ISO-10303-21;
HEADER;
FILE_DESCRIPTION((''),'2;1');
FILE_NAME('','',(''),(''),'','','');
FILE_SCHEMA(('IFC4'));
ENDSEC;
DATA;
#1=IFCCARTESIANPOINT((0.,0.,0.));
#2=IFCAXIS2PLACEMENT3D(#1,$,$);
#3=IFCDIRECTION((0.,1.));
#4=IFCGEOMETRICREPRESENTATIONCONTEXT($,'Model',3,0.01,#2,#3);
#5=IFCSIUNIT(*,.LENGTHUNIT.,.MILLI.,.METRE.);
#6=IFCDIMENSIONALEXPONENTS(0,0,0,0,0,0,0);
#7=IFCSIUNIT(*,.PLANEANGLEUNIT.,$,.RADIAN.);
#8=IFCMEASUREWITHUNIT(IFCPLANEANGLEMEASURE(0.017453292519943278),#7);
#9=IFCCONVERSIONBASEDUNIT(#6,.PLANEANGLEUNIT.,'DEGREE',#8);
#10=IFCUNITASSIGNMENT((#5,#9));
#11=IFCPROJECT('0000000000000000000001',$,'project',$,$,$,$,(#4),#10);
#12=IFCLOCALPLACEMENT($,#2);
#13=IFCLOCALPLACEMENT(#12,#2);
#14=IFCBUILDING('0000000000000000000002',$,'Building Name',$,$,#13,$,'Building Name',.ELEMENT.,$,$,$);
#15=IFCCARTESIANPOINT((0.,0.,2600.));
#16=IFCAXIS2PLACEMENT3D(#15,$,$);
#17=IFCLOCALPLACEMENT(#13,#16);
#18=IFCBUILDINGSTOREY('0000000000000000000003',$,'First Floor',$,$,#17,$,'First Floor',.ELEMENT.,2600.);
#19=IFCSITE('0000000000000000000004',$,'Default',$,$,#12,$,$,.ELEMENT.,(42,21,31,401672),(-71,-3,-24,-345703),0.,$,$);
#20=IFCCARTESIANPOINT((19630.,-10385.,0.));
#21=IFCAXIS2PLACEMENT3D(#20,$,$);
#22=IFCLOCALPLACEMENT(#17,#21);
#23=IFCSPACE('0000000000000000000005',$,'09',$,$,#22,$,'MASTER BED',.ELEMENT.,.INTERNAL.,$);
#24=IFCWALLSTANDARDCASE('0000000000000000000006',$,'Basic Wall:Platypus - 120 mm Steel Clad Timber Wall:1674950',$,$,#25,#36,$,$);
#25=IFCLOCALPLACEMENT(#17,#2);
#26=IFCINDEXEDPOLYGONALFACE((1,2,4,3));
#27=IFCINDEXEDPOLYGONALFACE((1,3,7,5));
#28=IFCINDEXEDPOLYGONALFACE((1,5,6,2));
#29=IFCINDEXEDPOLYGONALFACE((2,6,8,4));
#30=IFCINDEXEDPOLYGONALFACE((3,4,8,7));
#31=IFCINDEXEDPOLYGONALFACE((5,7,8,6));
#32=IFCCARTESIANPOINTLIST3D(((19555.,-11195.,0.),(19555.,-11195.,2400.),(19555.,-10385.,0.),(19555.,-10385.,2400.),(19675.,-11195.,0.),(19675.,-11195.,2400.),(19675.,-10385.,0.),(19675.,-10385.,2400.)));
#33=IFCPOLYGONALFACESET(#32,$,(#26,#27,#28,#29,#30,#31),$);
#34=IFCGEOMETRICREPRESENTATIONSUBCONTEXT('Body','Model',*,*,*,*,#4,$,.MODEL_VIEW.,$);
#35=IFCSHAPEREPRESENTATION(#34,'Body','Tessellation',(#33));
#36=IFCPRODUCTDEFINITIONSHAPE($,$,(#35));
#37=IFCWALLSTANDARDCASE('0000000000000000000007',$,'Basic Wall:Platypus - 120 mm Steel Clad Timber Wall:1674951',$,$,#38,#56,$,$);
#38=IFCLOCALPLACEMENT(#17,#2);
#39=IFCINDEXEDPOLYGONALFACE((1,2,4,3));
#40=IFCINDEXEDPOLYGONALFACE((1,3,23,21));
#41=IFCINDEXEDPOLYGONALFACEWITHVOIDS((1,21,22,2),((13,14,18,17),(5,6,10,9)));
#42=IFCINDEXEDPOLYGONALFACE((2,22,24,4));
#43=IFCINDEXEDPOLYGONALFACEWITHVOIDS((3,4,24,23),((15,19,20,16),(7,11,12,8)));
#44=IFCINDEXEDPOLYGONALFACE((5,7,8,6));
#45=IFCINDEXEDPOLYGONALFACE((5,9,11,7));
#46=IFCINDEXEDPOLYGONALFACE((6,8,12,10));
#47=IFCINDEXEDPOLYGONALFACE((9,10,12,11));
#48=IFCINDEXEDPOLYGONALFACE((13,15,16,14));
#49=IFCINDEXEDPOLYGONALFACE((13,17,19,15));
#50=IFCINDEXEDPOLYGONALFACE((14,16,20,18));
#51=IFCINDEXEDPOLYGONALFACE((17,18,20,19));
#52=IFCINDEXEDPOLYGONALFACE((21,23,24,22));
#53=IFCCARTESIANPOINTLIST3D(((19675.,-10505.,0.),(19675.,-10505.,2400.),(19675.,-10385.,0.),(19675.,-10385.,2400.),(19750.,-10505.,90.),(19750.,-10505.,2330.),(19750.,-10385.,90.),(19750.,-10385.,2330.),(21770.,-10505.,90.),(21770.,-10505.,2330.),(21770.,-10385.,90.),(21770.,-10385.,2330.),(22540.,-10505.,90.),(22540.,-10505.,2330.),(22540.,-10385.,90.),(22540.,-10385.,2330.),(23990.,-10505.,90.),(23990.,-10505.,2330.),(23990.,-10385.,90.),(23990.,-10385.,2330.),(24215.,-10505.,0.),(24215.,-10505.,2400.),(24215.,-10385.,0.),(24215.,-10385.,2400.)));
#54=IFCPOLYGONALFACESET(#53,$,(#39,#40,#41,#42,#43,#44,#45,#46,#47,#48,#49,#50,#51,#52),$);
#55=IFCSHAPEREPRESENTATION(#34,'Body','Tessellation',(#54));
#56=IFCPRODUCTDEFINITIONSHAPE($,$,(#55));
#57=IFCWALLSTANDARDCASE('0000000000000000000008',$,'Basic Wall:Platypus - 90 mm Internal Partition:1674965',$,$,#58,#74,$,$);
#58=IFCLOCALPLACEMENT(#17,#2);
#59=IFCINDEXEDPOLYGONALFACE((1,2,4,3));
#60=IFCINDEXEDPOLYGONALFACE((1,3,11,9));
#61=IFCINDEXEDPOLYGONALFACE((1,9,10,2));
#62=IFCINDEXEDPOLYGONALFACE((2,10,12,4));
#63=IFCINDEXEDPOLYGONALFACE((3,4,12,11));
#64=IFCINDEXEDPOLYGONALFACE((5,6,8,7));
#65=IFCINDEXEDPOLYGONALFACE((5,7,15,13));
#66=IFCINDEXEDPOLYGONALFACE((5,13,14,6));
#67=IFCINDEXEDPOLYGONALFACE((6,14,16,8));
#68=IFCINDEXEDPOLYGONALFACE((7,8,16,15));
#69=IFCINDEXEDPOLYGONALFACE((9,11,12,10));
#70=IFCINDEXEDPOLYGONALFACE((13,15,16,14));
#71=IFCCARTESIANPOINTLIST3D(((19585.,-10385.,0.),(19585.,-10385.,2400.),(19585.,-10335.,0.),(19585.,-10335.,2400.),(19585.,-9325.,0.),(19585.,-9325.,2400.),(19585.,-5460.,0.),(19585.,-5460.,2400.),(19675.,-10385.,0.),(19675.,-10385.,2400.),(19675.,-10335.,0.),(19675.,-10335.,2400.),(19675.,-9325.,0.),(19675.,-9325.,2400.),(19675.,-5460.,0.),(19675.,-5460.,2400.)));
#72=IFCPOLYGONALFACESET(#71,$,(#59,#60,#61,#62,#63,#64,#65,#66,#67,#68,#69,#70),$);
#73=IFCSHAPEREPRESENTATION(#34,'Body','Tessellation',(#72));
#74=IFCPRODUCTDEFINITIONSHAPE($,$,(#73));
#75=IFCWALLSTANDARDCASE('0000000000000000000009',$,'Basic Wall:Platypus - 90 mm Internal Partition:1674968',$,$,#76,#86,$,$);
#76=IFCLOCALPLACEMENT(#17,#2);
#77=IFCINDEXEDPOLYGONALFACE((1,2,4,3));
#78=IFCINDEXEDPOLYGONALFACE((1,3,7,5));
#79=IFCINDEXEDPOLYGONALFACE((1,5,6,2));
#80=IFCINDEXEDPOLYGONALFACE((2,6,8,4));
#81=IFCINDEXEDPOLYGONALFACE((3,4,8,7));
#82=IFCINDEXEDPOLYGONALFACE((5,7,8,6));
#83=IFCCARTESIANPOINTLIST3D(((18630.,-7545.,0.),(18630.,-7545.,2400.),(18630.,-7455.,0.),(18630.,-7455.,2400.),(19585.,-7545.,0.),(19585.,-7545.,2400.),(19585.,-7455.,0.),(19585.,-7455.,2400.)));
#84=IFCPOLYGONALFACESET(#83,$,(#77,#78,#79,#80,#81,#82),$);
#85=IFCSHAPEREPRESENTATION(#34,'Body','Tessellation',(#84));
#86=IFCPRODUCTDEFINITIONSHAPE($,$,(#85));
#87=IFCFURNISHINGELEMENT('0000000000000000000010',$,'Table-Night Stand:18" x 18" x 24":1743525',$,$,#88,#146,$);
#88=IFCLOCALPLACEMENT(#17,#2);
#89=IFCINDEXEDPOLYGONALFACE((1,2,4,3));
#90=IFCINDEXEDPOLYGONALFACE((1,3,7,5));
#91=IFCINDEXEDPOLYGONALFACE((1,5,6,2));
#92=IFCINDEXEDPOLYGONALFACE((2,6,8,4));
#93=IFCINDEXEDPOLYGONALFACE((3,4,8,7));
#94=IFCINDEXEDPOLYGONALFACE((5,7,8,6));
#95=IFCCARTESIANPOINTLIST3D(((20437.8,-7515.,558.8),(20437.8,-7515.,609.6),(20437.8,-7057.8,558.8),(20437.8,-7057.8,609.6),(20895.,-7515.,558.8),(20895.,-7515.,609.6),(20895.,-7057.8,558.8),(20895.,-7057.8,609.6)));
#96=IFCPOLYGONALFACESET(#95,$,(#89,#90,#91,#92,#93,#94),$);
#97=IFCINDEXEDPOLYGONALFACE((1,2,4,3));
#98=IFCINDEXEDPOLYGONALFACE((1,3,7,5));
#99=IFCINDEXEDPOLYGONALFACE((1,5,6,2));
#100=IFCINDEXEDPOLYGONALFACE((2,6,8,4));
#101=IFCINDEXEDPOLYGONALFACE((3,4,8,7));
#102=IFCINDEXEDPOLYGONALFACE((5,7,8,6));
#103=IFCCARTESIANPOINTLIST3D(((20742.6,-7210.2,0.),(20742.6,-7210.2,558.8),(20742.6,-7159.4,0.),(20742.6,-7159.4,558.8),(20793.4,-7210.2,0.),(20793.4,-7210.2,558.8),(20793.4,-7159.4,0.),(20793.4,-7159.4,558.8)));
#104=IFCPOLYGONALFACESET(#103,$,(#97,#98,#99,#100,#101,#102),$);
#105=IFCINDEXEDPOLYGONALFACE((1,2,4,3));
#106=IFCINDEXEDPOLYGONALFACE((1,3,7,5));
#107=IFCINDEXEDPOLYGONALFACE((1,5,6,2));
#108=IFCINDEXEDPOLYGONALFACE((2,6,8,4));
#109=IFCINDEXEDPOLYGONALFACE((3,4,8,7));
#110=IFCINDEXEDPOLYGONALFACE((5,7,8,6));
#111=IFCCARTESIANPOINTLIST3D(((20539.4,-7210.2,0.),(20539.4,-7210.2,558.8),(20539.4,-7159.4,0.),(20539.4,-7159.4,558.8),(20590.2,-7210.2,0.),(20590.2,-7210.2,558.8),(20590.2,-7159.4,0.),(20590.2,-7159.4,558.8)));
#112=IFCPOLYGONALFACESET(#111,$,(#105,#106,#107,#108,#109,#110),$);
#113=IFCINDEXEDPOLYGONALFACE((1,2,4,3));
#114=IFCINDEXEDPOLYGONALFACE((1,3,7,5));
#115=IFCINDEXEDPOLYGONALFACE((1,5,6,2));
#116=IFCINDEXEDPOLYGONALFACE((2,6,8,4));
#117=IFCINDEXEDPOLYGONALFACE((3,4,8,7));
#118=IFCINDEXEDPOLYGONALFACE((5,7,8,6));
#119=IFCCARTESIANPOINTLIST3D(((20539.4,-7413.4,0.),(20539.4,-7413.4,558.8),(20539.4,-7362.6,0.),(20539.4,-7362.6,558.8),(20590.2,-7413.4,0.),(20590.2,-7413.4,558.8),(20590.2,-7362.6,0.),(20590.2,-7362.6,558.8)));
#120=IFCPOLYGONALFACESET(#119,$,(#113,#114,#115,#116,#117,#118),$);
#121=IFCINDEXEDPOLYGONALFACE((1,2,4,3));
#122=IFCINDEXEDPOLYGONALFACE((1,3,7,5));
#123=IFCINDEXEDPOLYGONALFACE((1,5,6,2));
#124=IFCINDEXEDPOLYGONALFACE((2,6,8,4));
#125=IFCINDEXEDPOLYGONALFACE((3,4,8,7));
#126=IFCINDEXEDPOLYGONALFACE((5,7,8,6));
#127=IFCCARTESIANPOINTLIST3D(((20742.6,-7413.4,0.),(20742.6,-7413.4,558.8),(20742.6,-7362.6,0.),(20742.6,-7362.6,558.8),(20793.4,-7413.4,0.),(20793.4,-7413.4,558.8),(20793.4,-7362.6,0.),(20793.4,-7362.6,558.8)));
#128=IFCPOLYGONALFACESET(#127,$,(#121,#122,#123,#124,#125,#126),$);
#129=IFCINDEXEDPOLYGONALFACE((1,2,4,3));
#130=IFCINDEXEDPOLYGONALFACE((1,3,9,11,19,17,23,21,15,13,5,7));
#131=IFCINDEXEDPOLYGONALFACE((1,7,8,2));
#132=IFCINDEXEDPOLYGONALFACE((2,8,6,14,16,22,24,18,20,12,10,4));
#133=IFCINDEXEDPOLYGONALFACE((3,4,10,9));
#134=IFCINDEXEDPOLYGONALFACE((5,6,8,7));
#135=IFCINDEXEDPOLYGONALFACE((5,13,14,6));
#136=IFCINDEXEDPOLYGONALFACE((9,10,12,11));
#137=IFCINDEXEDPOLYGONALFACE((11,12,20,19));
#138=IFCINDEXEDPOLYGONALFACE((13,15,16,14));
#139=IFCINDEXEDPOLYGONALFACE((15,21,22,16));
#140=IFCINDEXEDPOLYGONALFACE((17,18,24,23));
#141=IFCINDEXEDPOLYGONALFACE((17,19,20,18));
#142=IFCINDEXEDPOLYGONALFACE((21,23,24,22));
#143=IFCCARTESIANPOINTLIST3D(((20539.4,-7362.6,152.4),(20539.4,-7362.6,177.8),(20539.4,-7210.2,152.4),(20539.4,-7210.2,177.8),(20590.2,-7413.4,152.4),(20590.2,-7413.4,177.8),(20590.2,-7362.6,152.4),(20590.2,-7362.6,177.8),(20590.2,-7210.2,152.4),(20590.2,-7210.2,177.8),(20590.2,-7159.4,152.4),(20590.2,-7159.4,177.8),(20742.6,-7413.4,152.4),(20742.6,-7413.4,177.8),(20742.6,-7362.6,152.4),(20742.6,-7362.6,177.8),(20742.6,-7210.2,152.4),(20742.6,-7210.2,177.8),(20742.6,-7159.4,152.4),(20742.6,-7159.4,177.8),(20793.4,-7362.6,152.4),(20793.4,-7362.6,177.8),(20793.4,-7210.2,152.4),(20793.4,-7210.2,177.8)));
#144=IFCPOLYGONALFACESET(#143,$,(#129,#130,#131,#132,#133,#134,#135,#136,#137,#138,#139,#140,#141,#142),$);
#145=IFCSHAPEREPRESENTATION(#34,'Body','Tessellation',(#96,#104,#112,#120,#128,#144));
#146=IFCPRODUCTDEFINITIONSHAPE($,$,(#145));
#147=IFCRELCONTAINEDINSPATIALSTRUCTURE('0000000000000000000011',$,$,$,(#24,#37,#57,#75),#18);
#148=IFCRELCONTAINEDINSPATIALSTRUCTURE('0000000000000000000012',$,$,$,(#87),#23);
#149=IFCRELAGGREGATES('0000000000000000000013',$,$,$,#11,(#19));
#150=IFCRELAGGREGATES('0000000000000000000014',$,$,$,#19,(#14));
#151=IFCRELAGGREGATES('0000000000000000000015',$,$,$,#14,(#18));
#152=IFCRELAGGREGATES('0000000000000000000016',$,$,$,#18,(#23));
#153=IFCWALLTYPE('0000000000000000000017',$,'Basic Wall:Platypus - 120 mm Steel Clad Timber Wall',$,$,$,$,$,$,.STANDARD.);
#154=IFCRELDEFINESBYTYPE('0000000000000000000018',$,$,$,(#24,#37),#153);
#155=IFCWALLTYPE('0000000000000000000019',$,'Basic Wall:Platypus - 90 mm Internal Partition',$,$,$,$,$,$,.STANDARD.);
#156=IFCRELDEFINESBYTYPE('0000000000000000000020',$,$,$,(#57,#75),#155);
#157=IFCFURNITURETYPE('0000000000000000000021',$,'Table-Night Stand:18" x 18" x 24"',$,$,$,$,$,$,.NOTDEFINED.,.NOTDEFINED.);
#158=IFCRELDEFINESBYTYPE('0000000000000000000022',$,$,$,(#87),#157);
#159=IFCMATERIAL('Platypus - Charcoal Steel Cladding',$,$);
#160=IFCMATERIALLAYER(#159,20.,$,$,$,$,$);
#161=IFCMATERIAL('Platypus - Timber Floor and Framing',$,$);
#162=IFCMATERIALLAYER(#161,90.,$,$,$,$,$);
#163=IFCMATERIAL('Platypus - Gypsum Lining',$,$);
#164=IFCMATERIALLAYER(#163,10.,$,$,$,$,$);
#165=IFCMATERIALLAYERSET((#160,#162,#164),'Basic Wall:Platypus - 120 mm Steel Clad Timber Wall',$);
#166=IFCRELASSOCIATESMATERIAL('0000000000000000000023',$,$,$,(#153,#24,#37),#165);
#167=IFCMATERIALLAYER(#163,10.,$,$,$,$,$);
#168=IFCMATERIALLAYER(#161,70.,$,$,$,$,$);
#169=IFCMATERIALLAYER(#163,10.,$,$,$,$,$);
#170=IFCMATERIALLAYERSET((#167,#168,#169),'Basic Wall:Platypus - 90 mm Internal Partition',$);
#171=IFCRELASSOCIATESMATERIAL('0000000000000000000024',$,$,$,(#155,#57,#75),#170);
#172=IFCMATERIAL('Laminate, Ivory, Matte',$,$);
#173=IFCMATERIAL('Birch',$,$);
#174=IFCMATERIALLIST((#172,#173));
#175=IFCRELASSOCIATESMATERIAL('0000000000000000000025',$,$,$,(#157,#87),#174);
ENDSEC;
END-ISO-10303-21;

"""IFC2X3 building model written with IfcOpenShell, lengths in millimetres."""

from ifc_helpers import new_model, entity, si_unit, converted_unit, direction, frame, frame_2d, origin, origin_2d_with_axis, place, context, subcontext, project, spatial, polyline, rectangle, outline, extrude, source, transform, mapped, material, material_list, layer, layer_set, layer_usage, type_object, type_shapes, element, save


model = new_model("IFC2X3")

# Units and contexts
model_context = context("Model", 3, precision=0.01, world=origin(), true_north=direction((0.0, 1.0)))
body_context = subcontext(model_context, "Body", "Model", "MODEL_VIEW")
ifc_project = project(units=[si_unit("LENGTHUNIT", "METRE", prefix="MILLI"), converted_unit("PLANEANGLEUNIT", "DEGREE", entity("IfcPlaneAngleMeasure", 0.017453292519943278), si_unit("PLANEANGLEUNIT", "RADIAN"), dimensions=[0, 0, 0, 0, 0, 0, 0])], contexts=[model_context])

# Site, building, storey
site_placement = place(None, origin())
site = spatial("IfcSite", under=ifc_project, at=site_placement, Name="Default", CompositionType="ELEMENT", RefLatitude=(42, 21, 31, 401672), RefLongitude=(-71, -3, -24, -345703), RefElevation=0.0)
building_placement = place(site_placement, origin())
building = spatial("IfcBuilding", under=site, at=building_placement, Name="Building Name", LongName="Building Name", CompositionType="ELEMENT")
storey_placement = place(building_placement, frame((0.0, 0.0, 2600.0)))
storey = spatial("IfcBuildingStorey", under=building, at=storey_placement, Name="First Floor", LongName="First Floor", CompositionType="ELEMENT", Elevation=2600.0)

# Wall
ifc_material_1 = material(Name="Platypus - Charcoal Steel Cladding")
ifc_layer_1 = layer(ifc_material_1, 20.0)
ifc_material_2 = material(Name="Platypus - Timber Floor and Framing")
ifc_layer_2 = layer(ifc_material_2, 90.0)
ifc_material_3 = material(Name="Platypus - Gypsum Lining")
ifc_layer_3 = layer(ifc_material_3, 10.0)
ifc_layer_set_1 = layer_set([ifc_layer_1, ifc_layer_2, ifc_layer_3], Name="Basic Wall:Platypus - 120 mm Steel Clad Timber Wall")
ifc_layer_usage_1 = layer_usage(ifc_layer_set_1, "AXIS2", "POSITIVE", -60.0)
wall_type_1 = type_object("IfcWallType", Name="Basic Wall:Platypus - 120 mm Steel Clad Timber Wall", PredefinedType="STANDARD", material=ifc_layer_set_1)
wall_1_placement = place(storey_placement, frame((19615.0, -11195.0, 0.0), z_axis=(0.0, 0.0, 1.0), x_axis=(0.0, 1.0, 0.0)))
element("IfcWallStandardCase", 1, at=wall_1_placement, inside=storey, type_object=wall_type_1, material=ifc_layer_usage_1, Name="Basic Wall:Platypus - 120 mm Steel Clad Timber Wall:1674950", context=body_context, shape_type="SweptSolid", body=[
    extrude(rectangle(XDim=810.0, YDim=120.0, at=frame_2d((405.0, 0.0), x_axis=(-1.0, 0.0))), origin(), (0.0, 0.0, 1.0), 2400.0),
])

# Wall, openings
ifc_layer_usage_2 = layer_usage(ifc_layer_set_1, "AXIS2", "POSITIVE", -60.0)
wall_2_placement = place(storey_placement, frame((19675.0, -10445.0, 0.0)))
wall_2 = element("IfcWallStandardCase", 2, at=wall_2_placement, inside=storey, type_object=wall_type_1, material=ifc_layer_usage_2, Name="Basic Wall:Platypus - 120 mm Steel Clad Timber Wall:1674951", context=body_context, shape_type="SweptSolid", body=[
    extrude(rectangle(XDim=4540.0, YDim=120.0, at=frame_2d((2270.0, 0.0), x_axis=(-1.0, 0.0))), origin(), (0.0, 0.0, 1.0), 2400.0),
])
opening_1_placement = place(wall_2_placement, frame((75.0, -60.0, 90.0)))
element("IfcOpeningElement", 3, at=opening_1_placement, cuts=wall_2, ObjectType="Opening", context=body_context, shape_type="SweptSolid", body=[
    extrude(rectangle(XDim=2240.0, YDim=2020.0, at=frame_2d((1120.0, 1010.0), x_axis=(-1.0, 0.0))), frame((0.0, 0.0, 0.0), z_axis=(0.0, 1.0, 0.0), x_axis=(0.0, 0.0, 1.0)), (0.0, 0.0, 1.0), 120.0),
])
opening_2_placement = place(wall_2_placement, frame((2865.0, -60.0, 90.0)))
element("IfcOpeningElement", 4, at=opening_2_placement, cuts=wall_2, ObjectType="Opening", context=body_context, shape_type="SweptSolid", body=[
    extrude(rectangle(XDim=2240.0, YDim=1450.0, at=frame_2d((1120.0, 725.0), x_axis=(-1.0, 0.0))), frame((0.0, 0.0, 0.0), z_axis=(0.0, 1.0, 0.0), x_axis=(0.0, 0.0, 1.0)), (0.0, 0.0, 1.0), 120.0),
])

# Wall, opening
ifc_layer_4 = layer(ifc_material_3, 10.0)
ifc_layer_5 = layer(ifc_material_2, 70.0)
ifc_layer_6 = layer(ifc_material_3, 10.0)
ifc_layer_set_2 = layer_set([ifc_layer_4, ifc_layer_5, ifc_layer_6], Name="Basic Wall:Platypus - 90 mm Internal Partition")
ifc_layer_usage_3 = layer_usage(ifc_layer_set_2, "AXIS2", "NEGATIVE", 45.0)
wall_type_2 = type_object("IfcWallType", Name="Basic Wall:Platypus - 90 mm Internal Partition", PredefinedType="STANDARD", material=ifc_layer_set_2)
wall_3_placement = place(storey_placement, frame((19630.0, -5460.0, 0.0), z_axis=(0.0, 0.0, 1.0), x_axis=(0.0, -1.0, 0.0)))
wall_3 = element("IfcWallStandardCase", 5, at=wall_3_placement, inside=storey, type_object=wall_type_2, material=ifc_layer_usage_3, Name="Basic Wall:Platypus - 90 mm Internal Partition:1674965", context=body_context, shape_type="SweptSolid", body=[
    extrude(rectangle(XDim=90.0, YDim=4925.0, at=frame_2d((2462.5, 0.0), x_axis=(0.0, -1.0))), origin(), (0.0, 0.0, 1.0), 2400.0),
])
opening_3_placement = place(wall_3_placement, frame((3865.0, -45.0, 0.0)))
element("IfcOpeningElement", 6, at=opening_3_placement, cuts=wall_3, ObjectType="Opening", context=body_context, shape_type="SweptSolid", body=[
    extrude(rectangle(XDim=2440.0, YDim=1010.0, at=frame_2d((1220.0, 505.0), x_axis=(1.0, 0.0))), frame((0.0, 0.0, 0.0), z_axis=(0.0, 1.0, 0.0), x_axis=(0.0, 0.0, 1.0)), (0.0, 0.0, 1.0), 90.0),
])

# Wall
ifc_layer_usage_4 = layer_usage(ifc_layer_set_2, "AXIS2", "NEGATIVE", 45.0)
wall_4_placement = place(storey_placement, frame((18630.0, -7500.0, 0.0)))
element("IfcWallStandardCase", 7, at=wall_4_placement, inside=storey, type_object=wall_type_2, material=ifc_layer_usage_4, Name="Basic Wall:Platypus - 90 mm Internal Partition:1674968", context=body_context, shape_type="SweptSolid", body=[
    extrude(rectangle(XDim=955.0, YDim=90.0, at=frame_2d((477.5, 0.0), x_axis=(-1.0, 0.0))), origin(), (0.0, 0.0, 1.0), 2400.0),
])

# Shared definitions
space_1_placement = place(storey_placement, frame((19630.0, -10385.0, 0.0)))
space_1 = spatial("IfcSpace", under=storey, at=space_1_placement, Name="09", LongName="MASTER BED", CompositionType="ELEMENT", InteriorOrExteriorSpace="INTERNAL")

# Furnishing element
ifc_material_4 = material(Name="Laminate, Ivory, Matte")
ifc_material_5 = material(Name="Birch")
ifc_material_list_1 = material_list([ifc_material_4, ifc_material_5])
furniture_type_1 = type_object("IfcFurnitureType", Name="Table-Night Stand:18\" x 18\" x 24\"", AssemblyPlace="NOTDEFINED", material=ifc_material_list_1)
shared_shape_1 = source(origin(), body_context, "Body", "SweptSolid", [
    extrude(rectangle(XDim=457.2, YDim=457.2, at=origin_2d_with_axis()), frame((232.3, 228.6, 558.8), z_axis=(0.0, 0.0, 1.0), x_axis=(0.0, 1.0, 0.0)), (0.0, 0.0, 1.0), 50.8),
    extrude(rectangle(XDim=50.8, YDim=50.8, at=origin_2d_with_axis()), frame((333.9, 330.2, 0.0), z_axis=(0.0, 0.0, 1.0), x_axis=(-1.0, 0.0, 0.0)), (0.0, 0.0, 1.0), 558.8),
    extrude(rectangle(XDim=50.8, YDim=50.8, at=frame_2d((0.0, 0.0), x_axis=(1.0, 0.0))), frame((130.7, 330.2, 0.0), z_axis=(0.0, 0.0, 1.0), x_axis=(-1.0, 0.0, 0.0)), (0.0, 0.0, 1.0), 558.8),
    extrude(rectangle(XDim=50.8, YDim=50.8, at=frame_2d((0.0, 0.0), x_axis=(1.0, 0.0))), frame((130.7, 127.0, 0.0), z_axis=(0.0, 0.0, 1.0), x_axis=(-1.0, 0.0, 0.0)), (0.0, 0.0, 1.0), 558.8),
    extrude(rectangle(XDim=50.8, YDim=50.8, at=frame_2d((0.0, 0.0), x_axis=(1.0, 0.0))), frame((333.9, 127.0, 0.0), z_axis=(0.0, 0.0, 1.0), x_axis=(-1.0, 0.0, 0.0)), (0.0, 0.0, 1.0), 558.8),
    extrude(outline(polyline([(-127.0, 76.2), (-127.0, -76.2), (-76.2, -76.2), (-76.2, -127.0), (76.2, -127.0), (76.2, -76.2), (127.0, -76.2), (127.0, 76.2), (76.2, 76.2), (76.2, 127.0), (-76.2, 127.0), (-76.2, 76.2), (-127.0, 76.2)])), frame((232.3, 228.6, 152.4), z_axis=(0.0, 0.0, -1.0), x_axis=(0.0, -1.0, 0.0)), (0.0, 0.0, -1.0), 25.4),
])
type_shapes(furniture_type_1, [shared_shape_1])
for number, where, name in (
    (8, (804.1, 2870.0, 0.0), "Table-Night Stand:18\" x 18\" x 24\":1743525"),
):
    element("IfcFurnishingElement", number, at=place(space_1_placement, frame(where)), inside=space_1, type_object=furniture_type_1, material=ifc_material_list_1, Name=name, context=body_context, shape_type="MappedRepresentation", body=[
        mapped(shared_shape_1, transform((0.0, 0.0, 0.0), scale=1.0)),
    ])

save(model, "model.ifc")
